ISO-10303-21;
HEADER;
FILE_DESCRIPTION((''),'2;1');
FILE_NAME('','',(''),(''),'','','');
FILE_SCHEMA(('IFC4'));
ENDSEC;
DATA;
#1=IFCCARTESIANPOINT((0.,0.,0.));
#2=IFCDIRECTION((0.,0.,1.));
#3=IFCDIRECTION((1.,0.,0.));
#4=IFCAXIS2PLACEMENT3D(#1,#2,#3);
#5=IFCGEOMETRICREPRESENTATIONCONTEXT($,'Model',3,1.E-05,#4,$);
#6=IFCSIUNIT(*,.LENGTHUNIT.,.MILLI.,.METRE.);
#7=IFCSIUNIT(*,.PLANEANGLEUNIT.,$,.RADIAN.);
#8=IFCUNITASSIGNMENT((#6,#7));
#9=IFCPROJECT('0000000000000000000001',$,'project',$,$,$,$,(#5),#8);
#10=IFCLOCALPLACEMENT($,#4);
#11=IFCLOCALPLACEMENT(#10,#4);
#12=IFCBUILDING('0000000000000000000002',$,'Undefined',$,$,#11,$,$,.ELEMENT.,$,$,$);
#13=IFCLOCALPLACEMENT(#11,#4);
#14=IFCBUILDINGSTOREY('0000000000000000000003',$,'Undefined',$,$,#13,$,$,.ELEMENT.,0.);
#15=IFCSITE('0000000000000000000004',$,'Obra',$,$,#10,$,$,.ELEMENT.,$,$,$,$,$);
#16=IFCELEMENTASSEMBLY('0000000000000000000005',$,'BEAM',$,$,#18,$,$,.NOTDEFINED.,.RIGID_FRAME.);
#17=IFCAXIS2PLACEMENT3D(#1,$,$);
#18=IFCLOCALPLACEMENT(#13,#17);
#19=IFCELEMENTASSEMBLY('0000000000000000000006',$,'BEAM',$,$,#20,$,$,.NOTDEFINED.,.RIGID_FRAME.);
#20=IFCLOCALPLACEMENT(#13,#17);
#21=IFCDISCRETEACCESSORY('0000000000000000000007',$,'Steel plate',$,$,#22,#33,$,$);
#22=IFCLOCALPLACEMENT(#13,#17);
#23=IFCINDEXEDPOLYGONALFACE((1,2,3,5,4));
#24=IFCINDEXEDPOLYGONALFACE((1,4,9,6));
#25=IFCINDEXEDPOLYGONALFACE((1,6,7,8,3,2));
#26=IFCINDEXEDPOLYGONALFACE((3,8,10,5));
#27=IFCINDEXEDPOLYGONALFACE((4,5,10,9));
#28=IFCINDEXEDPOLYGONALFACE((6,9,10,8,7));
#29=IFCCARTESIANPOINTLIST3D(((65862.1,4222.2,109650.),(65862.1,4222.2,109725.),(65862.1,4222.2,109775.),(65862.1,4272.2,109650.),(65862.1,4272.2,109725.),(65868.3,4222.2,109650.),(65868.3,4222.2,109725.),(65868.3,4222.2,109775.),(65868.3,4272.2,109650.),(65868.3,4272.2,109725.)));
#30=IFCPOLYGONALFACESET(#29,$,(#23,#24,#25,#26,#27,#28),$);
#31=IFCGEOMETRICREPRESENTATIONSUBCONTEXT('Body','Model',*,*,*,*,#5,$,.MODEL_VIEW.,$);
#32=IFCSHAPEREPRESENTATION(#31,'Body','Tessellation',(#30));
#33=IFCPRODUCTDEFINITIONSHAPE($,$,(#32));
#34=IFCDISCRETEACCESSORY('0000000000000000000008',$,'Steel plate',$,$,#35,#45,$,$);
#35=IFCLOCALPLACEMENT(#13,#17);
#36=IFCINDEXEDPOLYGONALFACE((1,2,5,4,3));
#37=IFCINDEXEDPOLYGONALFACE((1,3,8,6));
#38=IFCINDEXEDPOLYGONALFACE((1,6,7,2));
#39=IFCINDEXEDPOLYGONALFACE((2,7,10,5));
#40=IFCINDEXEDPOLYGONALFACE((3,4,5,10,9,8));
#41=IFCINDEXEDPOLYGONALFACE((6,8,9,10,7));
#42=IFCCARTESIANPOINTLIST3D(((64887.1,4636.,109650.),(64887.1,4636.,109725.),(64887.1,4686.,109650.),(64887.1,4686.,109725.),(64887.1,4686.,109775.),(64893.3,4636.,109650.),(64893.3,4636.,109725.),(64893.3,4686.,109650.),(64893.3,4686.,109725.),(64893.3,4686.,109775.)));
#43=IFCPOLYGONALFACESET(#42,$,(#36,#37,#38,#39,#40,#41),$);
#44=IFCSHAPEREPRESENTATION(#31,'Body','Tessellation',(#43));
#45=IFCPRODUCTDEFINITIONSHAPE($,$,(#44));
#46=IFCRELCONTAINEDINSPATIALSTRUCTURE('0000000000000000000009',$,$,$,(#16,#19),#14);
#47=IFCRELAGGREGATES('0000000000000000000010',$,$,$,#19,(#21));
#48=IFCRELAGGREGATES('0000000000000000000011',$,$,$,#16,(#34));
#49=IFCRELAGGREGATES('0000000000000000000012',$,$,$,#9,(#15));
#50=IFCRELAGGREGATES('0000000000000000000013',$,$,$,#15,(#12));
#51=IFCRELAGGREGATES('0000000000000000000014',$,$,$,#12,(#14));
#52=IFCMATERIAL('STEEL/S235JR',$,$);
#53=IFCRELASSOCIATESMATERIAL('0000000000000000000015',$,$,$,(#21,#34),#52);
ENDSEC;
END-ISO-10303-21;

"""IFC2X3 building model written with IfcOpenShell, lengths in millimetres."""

from ifc_helpers import new_model, si_unit, frame, origin_with_axes, place, context, subcontext, project, spatial, polyline, outline, extrude, material, element, aggregate, save


model = new_model("IFC2X3")

# Units and contexts
model_context = context("Model", 3, precision=1e-05, world=origin_with_axes())
body_context = subcontext(model_context, "Body", "Model", "MODEL_VIEW")
ifc_project = project(units=[si_unit("LENGTHUNIT", "METRE", prefix="MILLI"), si_unit("PLANEANGLEUNIT", "RADIAN")], contexts=[model_context])

# Site, building, storey
site_placement = place(None, origin_with_axes())
site = spatial("IfcSite", under=ifc_project, at=site_placement, Name="Obra", CompositionType="ELEMENT")
building_placement = place(site_placement, origin_with_axes())
building = spatial("IfcBuilding", under=site, at=building_placement, Name="Undefined", CompositionType="ELEMENT")
storey_placement = place(building_placement, origin_with_axes())
storey = spatial("IfcBuildingStorey", under=building, at=storey_placement, Name="Undefined", CompositionType="ELEMENT", Elevation=0.0)

# Element assembly
ifc_material_1 = material(Name="STEEL/S235JR")
assembly_1_placement = place(storey_placement, origin_with_axes())
assembly_1 = element("IfcElementAssembly", 1, at=assembly_1_placement, inside=storey, Name="BEAM", AssemblyPlace="NOTDEFINED", PredefinedType="RIGID_FRAME")

# Element assembly, discrete accessory
assembly_2_placement = place(storey_placement, origin_with_axes())
assembly_2 = element("IfcElementAssembly", 2, at=assembly_2_placement, inside=storey, Name="BEAM", AssemblyPlace="NOTDEFINED", PredefinedType="RIGID_FRAME")
discrete_accessory_1_placement = place(assembly_2_placement, frame((65865.2, 4222.2, 109725.0), z_axis=(1.0, 0.0, 0.0), x_axis=(0.0, 0.0, -1.0)))
discrete_accessory_1 = element("IfcDiscreteAccessory", 3, at=discrete_accessory_1_placement, material=ifc_material_1, Name="Steel plate", context=body_context, shape_type="SweptSolid", body=[
    extrude(outline(polyline([(0.0, 0.0), (75.0, 0.0), (75.0, 50.0), (0.0, 50.0), (-75.0, -25.0), (-75.0, 0.0), (0.0, 0.0)])), frame((0.0, 0.0, -3.1), z_axis=(0.0, 0.0, 1.0), x_axis=(1.0, 0.0, 0.0)), (0.0, 0.0, 1.0), 6.2),
])
aggregate(assembly_2, [discrete_accessory_1])

# Discrete accessory
discrete_accessory_2_placement = place(assembly_1_placement, frame((64890.2, 4686.0, 109725.0), z_axis=(-1.0, 0.0, 0.0), x_axis=(0.0, 0.0, -1.0)))
discrete_accessory_2 = element("IfcDiscreteAccessory", 4, at=discrete_accessory_2_placement, material=ifc_material_1, Name="Steel plate", context=body_context, shape_type="SweptSolid", body=[
    extrude(outline(polyline([(0.0, 0.0), (75.0, 0.0), (75.0, 50.0), (0.0, 50.0), (-75.0, -25.0), (-75.0, 0.0), (0.0, 0.0)])), frame((0.0, 0.0, -3.1), z_axis=(0.0, 0.0, 1.0), x_axis=(1.0, 0.0, 0.0)), (0.0, 0.0, 1.0), 6.2),
])
aggregate(assembly_1, [discrete_accessory_2])

save(model, "model.ifc")
